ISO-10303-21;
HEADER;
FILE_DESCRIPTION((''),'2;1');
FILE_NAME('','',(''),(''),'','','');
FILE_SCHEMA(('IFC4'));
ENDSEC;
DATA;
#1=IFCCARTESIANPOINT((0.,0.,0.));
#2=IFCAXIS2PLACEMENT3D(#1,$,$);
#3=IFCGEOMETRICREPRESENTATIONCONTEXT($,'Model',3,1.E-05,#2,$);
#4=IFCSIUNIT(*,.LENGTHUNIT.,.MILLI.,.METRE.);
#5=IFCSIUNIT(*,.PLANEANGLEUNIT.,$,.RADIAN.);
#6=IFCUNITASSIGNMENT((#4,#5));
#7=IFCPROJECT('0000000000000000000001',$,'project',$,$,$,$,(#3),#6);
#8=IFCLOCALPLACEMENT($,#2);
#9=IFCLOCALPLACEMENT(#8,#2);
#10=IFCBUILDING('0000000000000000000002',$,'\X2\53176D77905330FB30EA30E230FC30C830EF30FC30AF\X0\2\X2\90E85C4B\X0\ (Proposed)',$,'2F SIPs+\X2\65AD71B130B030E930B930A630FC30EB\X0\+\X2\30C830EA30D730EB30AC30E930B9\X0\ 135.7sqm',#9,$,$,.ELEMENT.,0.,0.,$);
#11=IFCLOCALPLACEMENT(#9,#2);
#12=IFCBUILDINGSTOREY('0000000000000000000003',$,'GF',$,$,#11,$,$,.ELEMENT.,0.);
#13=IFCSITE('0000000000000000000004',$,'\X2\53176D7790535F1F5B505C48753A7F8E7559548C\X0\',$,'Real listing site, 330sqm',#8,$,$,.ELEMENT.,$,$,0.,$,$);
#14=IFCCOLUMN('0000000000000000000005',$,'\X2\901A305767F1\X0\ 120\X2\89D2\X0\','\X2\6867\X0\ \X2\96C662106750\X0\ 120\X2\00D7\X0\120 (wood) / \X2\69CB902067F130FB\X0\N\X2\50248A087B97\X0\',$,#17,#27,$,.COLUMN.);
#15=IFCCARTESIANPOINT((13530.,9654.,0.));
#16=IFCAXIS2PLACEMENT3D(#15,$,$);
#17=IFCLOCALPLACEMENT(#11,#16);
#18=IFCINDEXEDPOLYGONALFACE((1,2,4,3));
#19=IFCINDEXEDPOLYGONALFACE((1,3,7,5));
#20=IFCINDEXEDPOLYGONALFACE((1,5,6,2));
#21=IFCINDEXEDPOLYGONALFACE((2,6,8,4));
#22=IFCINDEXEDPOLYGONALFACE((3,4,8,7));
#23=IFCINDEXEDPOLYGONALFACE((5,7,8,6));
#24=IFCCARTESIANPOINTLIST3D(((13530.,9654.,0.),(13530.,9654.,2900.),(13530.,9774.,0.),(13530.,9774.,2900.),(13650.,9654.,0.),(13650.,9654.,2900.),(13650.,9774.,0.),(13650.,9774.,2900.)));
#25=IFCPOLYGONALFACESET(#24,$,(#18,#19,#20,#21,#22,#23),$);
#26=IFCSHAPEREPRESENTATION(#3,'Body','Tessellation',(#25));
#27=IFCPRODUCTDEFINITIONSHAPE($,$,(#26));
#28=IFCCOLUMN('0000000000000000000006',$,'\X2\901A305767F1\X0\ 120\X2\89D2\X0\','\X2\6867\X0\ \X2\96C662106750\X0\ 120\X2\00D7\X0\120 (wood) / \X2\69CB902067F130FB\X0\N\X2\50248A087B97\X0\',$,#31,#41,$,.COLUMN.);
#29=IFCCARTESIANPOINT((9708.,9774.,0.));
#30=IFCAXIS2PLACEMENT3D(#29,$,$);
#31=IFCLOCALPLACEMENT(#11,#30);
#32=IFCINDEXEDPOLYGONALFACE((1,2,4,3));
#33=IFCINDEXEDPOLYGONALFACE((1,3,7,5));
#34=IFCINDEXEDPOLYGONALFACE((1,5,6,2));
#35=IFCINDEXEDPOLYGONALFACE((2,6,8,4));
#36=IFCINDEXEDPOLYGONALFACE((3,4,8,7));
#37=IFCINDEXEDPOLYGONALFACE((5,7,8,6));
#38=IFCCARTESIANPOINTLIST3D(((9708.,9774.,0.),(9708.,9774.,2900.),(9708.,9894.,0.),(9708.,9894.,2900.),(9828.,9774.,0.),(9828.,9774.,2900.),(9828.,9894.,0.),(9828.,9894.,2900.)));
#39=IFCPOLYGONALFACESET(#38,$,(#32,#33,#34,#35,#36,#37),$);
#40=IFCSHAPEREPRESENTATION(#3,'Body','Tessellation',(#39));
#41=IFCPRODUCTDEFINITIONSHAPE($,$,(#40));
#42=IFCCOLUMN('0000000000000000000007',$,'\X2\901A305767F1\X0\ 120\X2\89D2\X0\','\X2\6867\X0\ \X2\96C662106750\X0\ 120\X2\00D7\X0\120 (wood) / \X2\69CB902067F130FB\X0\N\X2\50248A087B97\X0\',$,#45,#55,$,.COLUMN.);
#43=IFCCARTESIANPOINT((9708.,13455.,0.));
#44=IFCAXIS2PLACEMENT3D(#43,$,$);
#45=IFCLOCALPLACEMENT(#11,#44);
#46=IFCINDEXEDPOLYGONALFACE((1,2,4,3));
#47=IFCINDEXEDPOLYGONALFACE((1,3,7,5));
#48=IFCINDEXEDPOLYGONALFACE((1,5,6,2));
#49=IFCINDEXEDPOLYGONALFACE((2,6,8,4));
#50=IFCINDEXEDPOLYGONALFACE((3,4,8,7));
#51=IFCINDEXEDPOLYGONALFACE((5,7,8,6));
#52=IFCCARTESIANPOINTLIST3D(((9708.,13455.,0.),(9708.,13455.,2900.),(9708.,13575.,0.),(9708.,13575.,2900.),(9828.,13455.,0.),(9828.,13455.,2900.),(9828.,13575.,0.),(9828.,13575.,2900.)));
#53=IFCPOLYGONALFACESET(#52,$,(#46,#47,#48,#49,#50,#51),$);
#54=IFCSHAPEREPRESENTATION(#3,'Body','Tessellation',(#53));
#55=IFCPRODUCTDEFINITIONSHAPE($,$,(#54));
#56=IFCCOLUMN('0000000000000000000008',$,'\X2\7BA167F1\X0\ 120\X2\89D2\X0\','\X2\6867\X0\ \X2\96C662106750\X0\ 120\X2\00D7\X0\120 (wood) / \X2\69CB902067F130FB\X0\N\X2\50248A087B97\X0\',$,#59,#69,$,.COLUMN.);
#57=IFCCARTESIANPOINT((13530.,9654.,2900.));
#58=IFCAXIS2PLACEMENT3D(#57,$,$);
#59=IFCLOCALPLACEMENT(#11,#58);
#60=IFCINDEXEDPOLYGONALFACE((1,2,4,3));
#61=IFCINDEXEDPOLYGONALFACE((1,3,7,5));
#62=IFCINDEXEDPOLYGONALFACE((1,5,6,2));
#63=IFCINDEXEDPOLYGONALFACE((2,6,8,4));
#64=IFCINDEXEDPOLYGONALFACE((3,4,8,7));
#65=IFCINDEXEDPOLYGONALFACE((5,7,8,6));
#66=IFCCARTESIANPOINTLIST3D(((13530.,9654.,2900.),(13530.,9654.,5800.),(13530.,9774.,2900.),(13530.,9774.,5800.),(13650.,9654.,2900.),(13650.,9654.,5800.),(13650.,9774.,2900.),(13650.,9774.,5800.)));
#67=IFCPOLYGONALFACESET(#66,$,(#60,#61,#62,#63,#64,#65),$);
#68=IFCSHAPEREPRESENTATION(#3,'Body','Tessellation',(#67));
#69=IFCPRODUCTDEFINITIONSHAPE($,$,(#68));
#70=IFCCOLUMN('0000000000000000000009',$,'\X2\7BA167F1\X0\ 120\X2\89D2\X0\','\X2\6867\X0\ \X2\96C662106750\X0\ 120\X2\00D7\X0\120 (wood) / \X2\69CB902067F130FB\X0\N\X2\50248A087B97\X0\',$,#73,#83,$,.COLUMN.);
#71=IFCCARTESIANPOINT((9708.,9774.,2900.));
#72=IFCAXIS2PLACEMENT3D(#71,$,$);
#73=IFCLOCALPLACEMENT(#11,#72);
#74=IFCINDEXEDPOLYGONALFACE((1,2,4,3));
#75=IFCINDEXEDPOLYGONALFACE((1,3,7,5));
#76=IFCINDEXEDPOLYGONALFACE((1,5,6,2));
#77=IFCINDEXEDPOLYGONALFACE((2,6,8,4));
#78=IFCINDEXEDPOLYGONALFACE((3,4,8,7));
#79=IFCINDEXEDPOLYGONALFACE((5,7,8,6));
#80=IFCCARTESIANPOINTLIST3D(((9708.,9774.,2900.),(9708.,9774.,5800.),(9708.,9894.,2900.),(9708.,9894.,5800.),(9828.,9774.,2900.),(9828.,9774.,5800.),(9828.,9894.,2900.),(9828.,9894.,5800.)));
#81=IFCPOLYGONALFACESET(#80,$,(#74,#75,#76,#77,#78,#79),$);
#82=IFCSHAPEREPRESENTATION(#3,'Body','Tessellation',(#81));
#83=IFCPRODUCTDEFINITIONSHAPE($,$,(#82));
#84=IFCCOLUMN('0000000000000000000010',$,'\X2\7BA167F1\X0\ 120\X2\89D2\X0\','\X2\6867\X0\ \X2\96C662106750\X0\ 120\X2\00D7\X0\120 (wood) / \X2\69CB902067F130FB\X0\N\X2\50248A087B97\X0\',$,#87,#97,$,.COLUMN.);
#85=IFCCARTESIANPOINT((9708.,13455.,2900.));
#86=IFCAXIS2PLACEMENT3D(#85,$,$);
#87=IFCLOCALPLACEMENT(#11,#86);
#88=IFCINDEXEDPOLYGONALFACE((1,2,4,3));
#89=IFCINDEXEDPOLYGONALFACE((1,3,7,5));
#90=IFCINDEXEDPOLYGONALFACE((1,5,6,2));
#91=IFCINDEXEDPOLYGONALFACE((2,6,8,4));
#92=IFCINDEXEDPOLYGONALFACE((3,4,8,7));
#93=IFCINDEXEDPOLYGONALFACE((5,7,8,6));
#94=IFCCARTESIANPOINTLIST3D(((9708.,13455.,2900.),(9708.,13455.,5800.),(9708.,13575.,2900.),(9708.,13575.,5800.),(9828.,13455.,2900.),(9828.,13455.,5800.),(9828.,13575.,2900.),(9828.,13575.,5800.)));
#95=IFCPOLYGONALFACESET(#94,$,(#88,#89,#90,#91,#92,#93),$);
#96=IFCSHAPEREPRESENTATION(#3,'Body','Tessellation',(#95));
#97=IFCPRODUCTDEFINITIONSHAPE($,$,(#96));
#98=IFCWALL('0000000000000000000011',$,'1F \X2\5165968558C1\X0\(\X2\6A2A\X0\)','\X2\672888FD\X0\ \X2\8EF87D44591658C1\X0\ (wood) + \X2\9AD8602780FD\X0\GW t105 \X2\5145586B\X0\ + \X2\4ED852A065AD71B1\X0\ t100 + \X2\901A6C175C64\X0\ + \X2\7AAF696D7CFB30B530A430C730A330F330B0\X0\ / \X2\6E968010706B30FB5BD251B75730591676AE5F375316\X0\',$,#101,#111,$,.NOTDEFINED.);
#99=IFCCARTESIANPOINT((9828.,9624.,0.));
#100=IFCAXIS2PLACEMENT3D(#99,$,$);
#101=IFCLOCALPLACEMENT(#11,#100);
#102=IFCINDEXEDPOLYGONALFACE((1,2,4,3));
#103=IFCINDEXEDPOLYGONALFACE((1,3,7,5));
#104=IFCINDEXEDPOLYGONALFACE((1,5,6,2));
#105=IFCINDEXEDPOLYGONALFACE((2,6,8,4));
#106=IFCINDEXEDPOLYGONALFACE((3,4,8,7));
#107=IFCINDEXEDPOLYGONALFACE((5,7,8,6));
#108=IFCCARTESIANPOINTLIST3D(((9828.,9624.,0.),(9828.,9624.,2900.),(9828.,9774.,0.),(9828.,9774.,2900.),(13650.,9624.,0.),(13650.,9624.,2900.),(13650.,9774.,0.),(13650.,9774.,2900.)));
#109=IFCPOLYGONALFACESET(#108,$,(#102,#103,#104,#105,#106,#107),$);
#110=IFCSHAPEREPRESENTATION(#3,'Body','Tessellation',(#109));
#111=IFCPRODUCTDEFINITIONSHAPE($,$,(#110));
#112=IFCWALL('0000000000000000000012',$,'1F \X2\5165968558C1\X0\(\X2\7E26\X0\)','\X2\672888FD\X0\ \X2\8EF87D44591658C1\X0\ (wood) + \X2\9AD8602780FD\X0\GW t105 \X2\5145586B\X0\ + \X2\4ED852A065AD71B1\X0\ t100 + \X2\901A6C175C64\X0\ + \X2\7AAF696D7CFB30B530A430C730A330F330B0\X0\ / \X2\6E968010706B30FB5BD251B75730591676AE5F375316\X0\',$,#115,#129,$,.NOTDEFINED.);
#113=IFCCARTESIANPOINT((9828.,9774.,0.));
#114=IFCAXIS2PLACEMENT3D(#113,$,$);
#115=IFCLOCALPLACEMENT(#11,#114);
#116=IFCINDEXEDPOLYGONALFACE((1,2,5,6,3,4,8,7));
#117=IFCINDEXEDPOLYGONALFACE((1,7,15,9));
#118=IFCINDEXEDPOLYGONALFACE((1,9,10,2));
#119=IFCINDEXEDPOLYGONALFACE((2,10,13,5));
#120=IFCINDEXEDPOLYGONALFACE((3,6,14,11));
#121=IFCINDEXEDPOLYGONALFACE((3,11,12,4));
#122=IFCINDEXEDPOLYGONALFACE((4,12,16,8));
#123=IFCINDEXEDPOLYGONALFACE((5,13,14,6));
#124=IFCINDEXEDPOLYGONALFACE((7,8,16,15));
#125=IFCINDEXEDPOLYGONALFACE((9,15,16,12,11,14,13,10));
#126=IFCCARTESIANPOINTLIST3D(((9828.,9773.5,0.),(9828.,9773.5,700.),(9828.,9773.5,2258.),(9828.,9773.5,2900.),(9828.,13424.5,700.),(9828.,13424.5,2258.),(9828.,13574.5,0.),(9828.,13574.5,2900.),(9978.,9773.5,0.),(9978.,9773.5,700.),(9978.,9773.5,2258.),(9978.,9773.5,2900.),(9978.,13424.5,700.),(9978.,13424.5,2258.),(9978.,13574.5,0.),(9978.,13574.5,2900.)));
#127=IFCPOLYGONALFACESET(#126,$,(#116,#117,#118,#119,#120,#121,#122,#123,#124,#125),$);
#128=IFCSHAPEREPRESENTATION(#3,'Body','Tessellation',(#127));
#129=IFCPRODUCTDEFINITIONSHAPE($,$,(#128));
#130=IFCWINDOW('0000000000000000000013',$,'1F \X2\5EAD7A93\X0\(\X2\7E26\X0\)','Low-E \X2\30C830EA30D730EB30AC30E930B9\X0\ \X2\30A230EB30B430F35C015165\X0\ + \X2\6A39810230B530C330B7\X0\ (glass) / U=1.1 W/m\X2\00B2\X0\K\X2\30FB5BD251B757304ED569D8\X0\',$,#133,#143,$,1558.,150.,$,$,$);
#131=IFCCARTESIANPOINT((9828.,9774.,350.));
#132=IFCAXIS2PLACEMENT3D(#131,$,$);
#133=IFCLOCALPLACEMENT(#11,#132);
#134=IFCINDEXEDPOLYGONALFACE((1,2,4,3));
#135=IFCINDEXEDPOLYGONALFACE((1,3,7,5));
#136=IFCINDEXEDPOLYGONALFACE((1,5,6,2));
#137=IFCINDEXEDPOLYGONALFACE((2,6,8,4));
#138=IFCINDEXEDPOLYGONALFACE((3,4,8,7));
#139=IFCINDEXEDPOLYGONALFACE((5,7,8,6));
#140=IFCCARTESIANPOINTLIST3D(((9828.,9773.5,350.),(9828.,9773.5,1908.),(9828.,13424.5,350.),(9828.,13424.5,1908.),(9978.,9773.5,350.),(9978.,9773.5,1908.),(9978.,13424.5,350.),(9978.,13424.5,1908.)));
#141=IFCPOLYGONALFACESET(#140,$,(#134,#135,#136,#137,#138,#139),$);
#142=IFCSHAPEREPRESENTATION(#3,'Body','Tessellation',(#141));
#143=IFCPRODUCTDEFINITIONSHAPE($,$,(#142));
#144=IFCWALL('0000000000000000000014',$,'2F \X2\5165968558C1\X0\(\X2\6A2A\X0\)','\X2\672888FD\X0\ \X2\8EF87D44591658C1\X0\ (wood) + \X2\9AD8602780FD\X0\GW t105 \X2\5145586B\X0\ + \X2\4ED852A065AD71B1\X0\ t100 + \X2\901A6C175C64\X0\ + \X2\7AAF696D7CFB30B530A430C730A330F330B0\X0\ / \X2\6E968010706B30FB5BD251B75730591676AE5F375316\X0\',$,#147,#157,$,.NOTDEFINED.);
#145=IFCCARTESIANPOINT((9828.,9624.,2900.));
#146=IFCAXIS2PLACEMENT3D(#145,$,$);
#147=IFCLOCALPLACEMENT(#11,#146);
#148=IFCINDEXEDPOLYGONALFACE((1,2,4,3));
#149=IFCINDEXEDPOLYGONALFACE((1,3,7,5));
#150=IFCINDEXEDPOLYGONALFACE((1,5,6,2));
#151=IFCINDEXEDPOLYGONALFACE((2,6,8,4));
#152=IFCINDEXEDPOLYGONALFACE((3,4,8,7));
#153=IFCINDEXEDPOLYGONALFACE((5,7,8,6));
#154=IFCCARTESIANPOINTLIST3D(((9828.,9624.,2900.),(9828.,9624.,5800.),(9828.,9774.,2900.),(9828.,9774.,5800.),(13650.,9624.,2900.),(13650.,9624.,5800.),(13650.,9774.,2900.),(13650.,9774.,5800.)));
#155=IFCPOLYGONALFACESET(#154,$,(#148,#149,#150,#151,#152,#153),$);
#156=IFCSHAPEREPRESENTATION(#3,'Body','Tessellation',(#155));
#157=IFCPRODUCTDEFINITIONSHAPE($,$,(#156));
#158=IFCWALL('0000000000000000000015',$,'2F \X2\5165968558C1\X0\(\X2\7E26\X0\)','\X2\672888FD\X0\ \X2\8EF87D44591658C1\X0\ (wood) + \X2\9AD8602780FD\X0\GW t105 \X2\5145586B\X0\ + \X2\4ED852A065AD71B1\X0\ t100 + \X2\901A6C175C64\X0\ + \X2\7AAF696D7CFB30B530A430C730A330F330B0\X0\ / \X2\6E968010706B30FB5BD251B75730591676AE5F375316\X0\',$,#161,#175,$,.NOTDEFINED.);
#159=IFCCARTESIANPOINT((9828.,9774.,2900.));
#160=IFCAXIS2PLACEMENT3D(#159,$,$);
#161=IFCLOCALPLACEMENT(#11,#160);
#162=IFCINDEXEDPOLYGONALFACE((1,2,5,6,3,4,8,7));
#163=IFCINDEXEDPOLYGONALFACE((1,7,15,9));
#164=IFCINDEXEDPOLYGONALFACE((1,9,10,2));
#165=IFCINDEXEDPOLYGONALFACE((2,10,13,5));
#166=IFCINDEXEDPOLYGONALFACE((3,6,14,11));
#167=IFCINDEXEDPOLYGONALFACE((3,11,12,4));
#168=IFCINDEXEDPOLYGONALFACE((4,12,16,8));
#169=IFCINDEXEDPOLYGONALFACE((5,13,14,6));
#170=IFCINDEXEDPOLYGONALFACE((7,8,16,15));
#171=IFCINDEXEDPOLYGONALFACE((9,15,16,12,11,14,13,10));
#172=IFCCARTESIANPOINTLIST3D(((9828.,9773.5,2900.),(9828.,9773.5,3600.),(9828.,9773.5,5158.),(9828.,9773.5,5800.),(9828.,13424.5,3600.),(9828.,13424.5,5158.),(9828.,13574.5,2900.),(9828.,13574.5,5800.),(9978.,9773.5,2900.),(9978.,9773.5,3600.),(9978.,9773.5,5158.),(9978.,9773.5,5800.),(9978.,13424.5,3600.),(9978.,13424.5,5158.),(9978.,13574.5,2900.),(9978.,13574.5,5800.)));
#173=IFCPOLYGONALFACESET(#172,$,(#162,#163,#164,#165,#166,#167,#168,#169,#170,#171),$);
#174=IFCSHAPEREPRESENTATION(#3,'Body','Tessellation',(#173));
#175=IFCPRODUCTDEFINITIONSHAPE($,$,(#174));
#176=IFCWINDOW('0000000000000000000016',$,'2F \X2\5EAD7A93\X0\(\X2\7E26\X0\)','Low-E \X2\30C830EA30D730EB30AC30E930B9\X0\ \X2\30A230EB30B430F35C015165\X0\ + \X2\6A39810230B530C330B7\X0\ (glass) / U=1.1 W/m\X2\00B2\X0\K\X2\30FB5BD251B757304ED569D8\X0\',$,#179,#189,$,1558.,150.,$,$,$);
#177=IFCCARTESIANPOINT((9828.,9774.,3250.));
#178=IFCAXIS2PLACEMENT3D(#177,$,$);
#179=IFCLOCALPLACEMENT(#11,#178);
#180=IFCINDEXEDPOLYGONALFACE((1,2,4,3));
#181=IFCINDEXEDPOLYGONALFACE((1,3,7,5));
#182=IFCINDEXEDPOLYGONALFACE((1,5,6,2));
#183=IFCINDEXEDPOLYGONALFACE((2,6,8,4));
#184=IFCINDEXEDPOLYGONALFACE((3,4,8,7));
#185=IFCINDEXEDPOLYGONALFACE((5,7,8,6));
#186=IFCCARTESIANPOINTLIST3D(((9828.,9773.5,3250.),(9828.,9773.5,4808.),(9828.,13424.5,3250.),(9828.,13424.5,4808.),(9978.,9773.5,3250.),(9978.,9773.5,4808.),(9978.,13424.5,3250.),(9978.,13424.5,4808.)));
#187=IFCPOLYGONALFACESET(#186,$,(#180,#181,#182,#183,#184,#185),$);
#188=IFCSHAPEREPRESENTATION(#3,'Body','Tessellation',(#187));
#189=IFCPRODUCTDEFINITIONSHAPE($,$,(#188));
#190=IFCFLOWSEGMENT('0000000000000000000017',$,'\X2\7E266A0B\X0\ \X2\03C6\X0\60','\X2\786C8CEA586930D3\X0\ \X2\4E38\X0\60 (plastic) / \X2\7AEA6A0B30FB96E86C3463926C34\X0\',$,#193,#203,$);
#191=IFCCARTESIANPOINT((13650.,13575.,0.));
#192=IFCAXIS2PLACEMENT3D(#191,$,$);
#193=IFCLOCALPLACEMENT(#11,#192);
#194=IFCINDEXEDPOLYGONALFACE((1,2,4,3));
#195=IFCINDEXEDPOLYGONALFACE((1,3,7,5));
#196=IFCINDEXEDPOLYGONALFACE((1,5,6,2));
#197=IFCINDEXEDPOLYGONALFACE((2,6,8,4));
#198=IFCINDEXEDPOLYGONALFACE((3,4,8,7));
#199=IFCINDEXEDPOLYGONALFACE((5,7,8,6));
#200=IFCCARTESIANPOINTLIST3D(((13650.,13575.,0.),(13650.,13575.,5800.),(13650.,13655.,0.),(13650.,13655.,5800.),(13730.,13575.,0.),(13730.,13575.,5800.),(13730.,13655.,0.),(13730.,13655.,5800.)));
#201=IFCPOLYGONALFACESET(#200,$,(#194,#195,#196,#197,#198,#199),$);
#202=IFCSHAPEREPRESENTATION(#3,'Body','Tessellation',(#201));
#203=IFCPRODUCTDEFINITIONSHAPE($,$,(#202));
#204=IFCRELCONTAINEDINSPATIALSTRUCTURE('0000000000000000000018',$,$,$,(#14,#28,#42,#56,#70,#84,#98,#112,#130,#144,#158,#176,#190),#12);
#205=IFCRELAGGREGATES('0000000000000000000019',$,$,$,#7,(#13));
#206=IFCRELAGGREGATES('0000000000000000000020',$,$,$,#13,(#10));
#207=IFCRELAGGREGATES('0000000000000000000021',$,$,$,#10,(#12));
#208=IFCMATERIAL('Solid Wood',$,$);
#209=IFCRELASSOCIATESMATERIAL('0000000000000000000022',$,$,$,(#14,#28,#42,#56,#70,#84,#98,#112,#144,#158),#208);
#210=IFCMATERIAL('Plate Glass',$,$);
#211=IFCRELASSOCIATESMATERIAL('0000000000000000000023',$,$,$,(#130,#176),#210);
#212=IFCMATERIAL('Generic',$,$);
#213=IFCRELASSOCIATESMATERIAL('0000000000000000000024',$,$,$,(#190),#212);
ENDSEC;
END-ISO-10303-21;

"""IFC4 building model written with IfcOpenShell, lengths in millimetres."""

from ifc_helpers import new_model, si_unit, frame, frame_2d, origin, place, context, project, spatial, rectangle, extrude, material, element, fill, save


model = new_model("IFC4")

# Units and contexts
model_context = context("Model", 3, precision=1e-05, world=origin())
ifc_project = project(units=[si_unit("LENGTHUNIT", "METRE", prefix="MILLI"), si_unit("PLANEANGLEUNIT", "RADIAN")], contexts=[model_context])

# Site, building, storey
site_placement = place(None, origin())
site = spatial("IfcSite", under=ifc_project, at=site_placement, Name="北海道弟子屈町美留和", ObjectType="Real listing site, 330sqm", CompositionType="ELEMENT", RefElevation=0.0)
building_placement = place(site_placement, origin())
building = spatial("IfcBuilding", under=site, at=building_placement, Name="北海道・リモートワーク2部屋 (Proposed)", ObjectType="2F SIPs+断熱グラスウール+トリプルガラス 135.7sqm", CompositionType="ELEMENT", ElevationOfRefHeight=0.0, ElevationOfTerrain=0.0)
storey_placement = place(building_placement, origin())
storey = spatial("IfcBuildingStorey", under=building, at=storey_placement, Name="GF", CompositionType="ELEMENT", Elevation=0.0)

# Columns
ifc_material_1 = material(Name="Solid Wood")
column_1_placement = place(storey_placement, frame((13530.0, 9654.0, 0.0)))
element("IfcColumn", 1, at=column_1_placement, inside=storey, material=ifc_material_1, Name="通し柱 120角", Description="桧 集成材 120×120 (wood) / 構造柱・N値計算", PredefinedType="COLUMN", context=model_context, shape_type="SweptSolid", body=[
    extrude(rectangle(XDim=120.0, YDim=120.0, at=frame_2d((60.0, 60.0))), frame((13530.0, 9654.0, 0.0)), (0.0, 0.0, 1.0), 2900.0),
])
column_2_placement = place(storey_placement, frame((9708.0, 9774.0, 0.0)))
element("IfcColumn", 2, at=column_2_placement, inside=storey, material=ifc_material_1, Name="通し柱 120角", Description="桧 集成材 120×120 (wood) / 構造柱・N値計算", PredefinedType="COLUMN", context=model_context, shape_type="SweptSolid", body=[
    extrude(rectangle(XDim=120.0, YDim=120.0, at=frame_2d((60.0, 60.0))), frame((9708.0, 9774.0, 0.0)), (0.0, 0.0, 1.0), 2900.0),
])
column_3_placement = place(storey_placement, frame((9708.0, 13455.0, 0.0)))
element("IfcColumn", 3, at=column_3_placement, inside=storey, material=ifc_material_1, Name="通し柱 120角", Description="桧 集成材 120×120 (wood) / 構造柱・N値計算", PredefinedType="COLUMN", context=model_context, shape_type="SweptSolid", body=[
    extrude(rectangle(XDim=120.0, YDim=120.0, at=frame_2d((60.0, 60.0))), frame((9708.0, 13455.0, 0.0)), (0.0, 0.0, 1.0), 2900.0),
])
column_4_placement = place(storey_placement, frame((13530.0, 9654.0, 2900.0)))
element("IfcColumn", 4, at=column_4_placement, inside=storey, material=ifc_material_1, Name="管柱 120角", Description="桧 集成材 120×120 (wood) / 構造柱・N値計算", PredefinedType="COLUMN", context=model_context, shape_type="SweptSolid", body=[
    extrude(rectangle(XDim=120.0, YDim=120.0, at=frame_2d((60.0, 60.0))), frame((13530.0, 9654.0, 2900.0)), (0.0, 0.0, 1.0), 2900.0),
])
column_5_placement = place(storey_placement, frame((9708.0, 9774.0, 2900.0)))
element("IfcColumn", 5, at=column_5_placement, inside=storey, material=ifc_material_1, Name="管柱 120角", Description="桧 集成材 120×120 (wood) / 構造柱・N値計算", PredefinedType="COLUMN", context=model_context, shape_type="SweptSolid", body=[
    extrude(rectangle(XDim=120.0, YDim=120.0, at=frame_2d((60.0, 60.0))), frame((9708.0, 9774.0, 2900.0)), (0.0, 0.0, 1.0), 2900.0),
])
column_6_placement = place(storey_placement, frame((9708.0, 13455.0, 2900.0)))
element("IfcColumn", 6, at=column_6_placement, inside=storey, material=ifc_material_1, Name="管柱 120角", Description="桧 集成材 120×120 (wood) / 構造柱・N値計算", PredefinedType="COLUMN", context=model_context, shape_type="SweptSolid", body=[
    extrude(rectangle(XDim=120.0, YDim=120.0, at=frame_2d((60.0, 60.0))), frame((9708.0, 13455.0, 2900.0)), (0.0, 0.0, 1.0), 2900.0),
])

# Wall
wall_1_placement = place(storey_placement, frame((9828.0, 9624.0, 0.0)))
element("IfcWall", 7, at=wall_1_placement, inside=storey, material=ifc_material_1, Name="1F 入隅壁(横)", Description="木製 軸組外壁 (wood) + 高性能GW t105 充填 + 付加断熱 t100 + 通気層 + 窯業系サイディング / 準耐火・寒冷地外皮強化", PredefinedType="NOTDEFINED", context=model_context, shape_type="SweptSolid", body=[
    extrude(rectangle(XDim=3822.0, YDim=150.0, at=frame_2d((1911.0, 75.0))), frame((9828.0, 9624.0, 0.0)), (0.0, 0.0, 1.0), 2900.0),
])

# Wall, opening, window
wall_2_placement = place(storey_placement, frame((9828.0, 9774.0, 0.0)))
wall_2 = element("IfcWall", 8, at=wall_2_placement, inside=storey, material=ifc_material_1, Name="1F 入隅壁(縦)", Description="木製 軸組外壁 (wood) + 高性能GW t105 充填 + 付加断熱 t100 + 通気層 + 窯業系サイディング / 準耐火・寒冷地外皮強化", PredefinedType="NOTDEFINED", context=model_context, shape_type="SweptSolid", body=[
    extrude(rectangle(XDim=150.0, YDim=3801.0, at=frame_2d((75.0, 1900.0))), frame((9828.0, 9774.0, 0.0)), (0.0, 0.0, 1.0), 2900.0),
])
opening_1_placement = place(storey_placement, frame((9828.0, 9774.0, 350.0)))
opening_1 = element("IfcOpeningElement", 9, at=opening_1_placement, cuts=wall_2, PredefinedType="NOTDEFINED", context=model_context, shape_type="SweptSolid", body=[
    extrude(rectangle(XDim=150.0, YDim=3651.0, at=frame_2d((75.0, 1825.0))), frame((9828.0, 9774.0, 350.0)), (0.0, 0.0, 1.0), 1558.0),
])
ifc_material_2 = material(Name="Plate Glass")
window_1_placement = place(storey_placement, frame((9828.0, 9774.0, 350.0)))
window_1 = element("IfcWindow", 10, at=window_1_placement, inside=storey, material=ifc_material_2, Name="1F 庭窓(縦)", Description="Low-E トリプルガラス アルゴン封入 + 樹脂サッシ (glass) / U=1.1 W/m²K・寒冷地仕様", OverallHeight=1558.0, OverallWidth=150.0, context=model_context, shape_type="SweptSolid", body=[
    extrude(rectangle(XDim=150.0, YDim=3651.0, at=frame_2d((75.0, 1825.0))), frame((9828.0, 9774.0, 350.0)), (0.0, 0.0, 1.0), 1558.0),
])
fill(opening_1, window_1)

# Wall
wall_3_placement = place(storey_placement, frame((9828.0, 9624.0, 2900.0)))
element("IfcWall", 11, at=wall_3_placement, inside=storey, material=ifc_material_1, Name="2F 入隅壁(横)", Description="木製 軸組外壁 (wood) + 高性能GW t105 充填 + 付加断熱 t100 + 通気層 + 窯業系サイディング / 準耐火・寒冷地外皮強化", PredefinedType="NOTDEFINED", context=model_context, shape_type="SweptSolid", body=[
    extrude(rectangle(XDim=3822.0, YDim=150.0, at=frame_2d((1911.0, 75.0))), frame((9828.0, 9624.0, 2900.0)), (0.0, 0.0, 1.0), 2900.0),
])

# Wall, opening, window
wall_4_placement = place(storey_placement, frame((9828.0, 9774.0, 2900.0)))
wall_4 = element("IfcWall", 12, at=wall_4_placement, inside=storey, material=ifc_material_1, Name="2F 入隅壁(縦)", Description="木製 軸組外壁 (wood) + 高性能GW t105 充填 + 付加断熱 t100 + 通気層 + 窯業系サイディング / 準耐火・寒冷地外皮強化", PredefinedType="NOTDEFINED", context=model_context, shape_type="SweptSolid", body=[
    extrude(rectangle(XDim=150.0, YDim=3801.0, at=frame_2d((75.0, 1900.0))), frame((9828.0, 9774.0, 2900.0)), (0.0, 0.0, 1.0), 2900.0),
])
opening_2_placement = place(storey_placement, frame((9828.0, 9774.0, 3250.0)))
opening_2 = element("IfcOpeningElement", 13, at=opening_2_placement, cuts=wall_4, PredefinedType="NOTDEFINED", context=model_context, shape_type="SweptSolid", body=[
    extrude(rectangle(XDim=150.0, YDim=3651.0, at=frame_2d((75.0, 1825.0))), frame((9828.0, 9774.0, 3250.0)), (0.0, 0.0, 1.0), 1558.0),
])
window_2_placement = place(storey_placement, frame((9828.0, 9774.0, 3250.0)))
window_2 = element("IfcWindow", 14, at=window_2_placement, inside=storey, material=ifc_material_2, Name="2F 庭窓(縦)", Description="Low-E トリプルガラス アルゴン封入 + 樹脂サッシ (glass) / U=1.1 W/m²K・寒冷地仕様", OverallHeight=1558.0, OverallWidth=150.0, context=model_context, shape_type="SweptSolid", body=[
    extrude(rectangle(XDim=150.0, YDim=3651.0, at=frame_2d((75.0, 1825.0))), frame((9828.0, 9774.0, 3250.0)), (0.0, 0.0, 1.0), 1558.0),
])
fill(opening_2, window_2)

# Flow segment
ifc_material_3 = material(Name="Generic")
flow_segment_placement = place(storey_placement, frame((13650.0, 13575.0, 0.0)))
element("IfcFlowSegment", 15, at=flow_segment_placement, inside=storey, material=ifc_material_3, Name="縦樋 φ60", Description="硬質塩ビ 丸60 (plastic) / 竪樋・雨水排水", context=model_context, shape_type="SweptSolid", body=[
    extrude(rectangle(XDim=80.0, YDim=80.0, at=frame_2d((40.0, 40.0))), frame((13650.0, 13575.0, 0.0)), (0.0, 0.0, 1.0), 5800.0),
])

save(model, "model.ifc")
